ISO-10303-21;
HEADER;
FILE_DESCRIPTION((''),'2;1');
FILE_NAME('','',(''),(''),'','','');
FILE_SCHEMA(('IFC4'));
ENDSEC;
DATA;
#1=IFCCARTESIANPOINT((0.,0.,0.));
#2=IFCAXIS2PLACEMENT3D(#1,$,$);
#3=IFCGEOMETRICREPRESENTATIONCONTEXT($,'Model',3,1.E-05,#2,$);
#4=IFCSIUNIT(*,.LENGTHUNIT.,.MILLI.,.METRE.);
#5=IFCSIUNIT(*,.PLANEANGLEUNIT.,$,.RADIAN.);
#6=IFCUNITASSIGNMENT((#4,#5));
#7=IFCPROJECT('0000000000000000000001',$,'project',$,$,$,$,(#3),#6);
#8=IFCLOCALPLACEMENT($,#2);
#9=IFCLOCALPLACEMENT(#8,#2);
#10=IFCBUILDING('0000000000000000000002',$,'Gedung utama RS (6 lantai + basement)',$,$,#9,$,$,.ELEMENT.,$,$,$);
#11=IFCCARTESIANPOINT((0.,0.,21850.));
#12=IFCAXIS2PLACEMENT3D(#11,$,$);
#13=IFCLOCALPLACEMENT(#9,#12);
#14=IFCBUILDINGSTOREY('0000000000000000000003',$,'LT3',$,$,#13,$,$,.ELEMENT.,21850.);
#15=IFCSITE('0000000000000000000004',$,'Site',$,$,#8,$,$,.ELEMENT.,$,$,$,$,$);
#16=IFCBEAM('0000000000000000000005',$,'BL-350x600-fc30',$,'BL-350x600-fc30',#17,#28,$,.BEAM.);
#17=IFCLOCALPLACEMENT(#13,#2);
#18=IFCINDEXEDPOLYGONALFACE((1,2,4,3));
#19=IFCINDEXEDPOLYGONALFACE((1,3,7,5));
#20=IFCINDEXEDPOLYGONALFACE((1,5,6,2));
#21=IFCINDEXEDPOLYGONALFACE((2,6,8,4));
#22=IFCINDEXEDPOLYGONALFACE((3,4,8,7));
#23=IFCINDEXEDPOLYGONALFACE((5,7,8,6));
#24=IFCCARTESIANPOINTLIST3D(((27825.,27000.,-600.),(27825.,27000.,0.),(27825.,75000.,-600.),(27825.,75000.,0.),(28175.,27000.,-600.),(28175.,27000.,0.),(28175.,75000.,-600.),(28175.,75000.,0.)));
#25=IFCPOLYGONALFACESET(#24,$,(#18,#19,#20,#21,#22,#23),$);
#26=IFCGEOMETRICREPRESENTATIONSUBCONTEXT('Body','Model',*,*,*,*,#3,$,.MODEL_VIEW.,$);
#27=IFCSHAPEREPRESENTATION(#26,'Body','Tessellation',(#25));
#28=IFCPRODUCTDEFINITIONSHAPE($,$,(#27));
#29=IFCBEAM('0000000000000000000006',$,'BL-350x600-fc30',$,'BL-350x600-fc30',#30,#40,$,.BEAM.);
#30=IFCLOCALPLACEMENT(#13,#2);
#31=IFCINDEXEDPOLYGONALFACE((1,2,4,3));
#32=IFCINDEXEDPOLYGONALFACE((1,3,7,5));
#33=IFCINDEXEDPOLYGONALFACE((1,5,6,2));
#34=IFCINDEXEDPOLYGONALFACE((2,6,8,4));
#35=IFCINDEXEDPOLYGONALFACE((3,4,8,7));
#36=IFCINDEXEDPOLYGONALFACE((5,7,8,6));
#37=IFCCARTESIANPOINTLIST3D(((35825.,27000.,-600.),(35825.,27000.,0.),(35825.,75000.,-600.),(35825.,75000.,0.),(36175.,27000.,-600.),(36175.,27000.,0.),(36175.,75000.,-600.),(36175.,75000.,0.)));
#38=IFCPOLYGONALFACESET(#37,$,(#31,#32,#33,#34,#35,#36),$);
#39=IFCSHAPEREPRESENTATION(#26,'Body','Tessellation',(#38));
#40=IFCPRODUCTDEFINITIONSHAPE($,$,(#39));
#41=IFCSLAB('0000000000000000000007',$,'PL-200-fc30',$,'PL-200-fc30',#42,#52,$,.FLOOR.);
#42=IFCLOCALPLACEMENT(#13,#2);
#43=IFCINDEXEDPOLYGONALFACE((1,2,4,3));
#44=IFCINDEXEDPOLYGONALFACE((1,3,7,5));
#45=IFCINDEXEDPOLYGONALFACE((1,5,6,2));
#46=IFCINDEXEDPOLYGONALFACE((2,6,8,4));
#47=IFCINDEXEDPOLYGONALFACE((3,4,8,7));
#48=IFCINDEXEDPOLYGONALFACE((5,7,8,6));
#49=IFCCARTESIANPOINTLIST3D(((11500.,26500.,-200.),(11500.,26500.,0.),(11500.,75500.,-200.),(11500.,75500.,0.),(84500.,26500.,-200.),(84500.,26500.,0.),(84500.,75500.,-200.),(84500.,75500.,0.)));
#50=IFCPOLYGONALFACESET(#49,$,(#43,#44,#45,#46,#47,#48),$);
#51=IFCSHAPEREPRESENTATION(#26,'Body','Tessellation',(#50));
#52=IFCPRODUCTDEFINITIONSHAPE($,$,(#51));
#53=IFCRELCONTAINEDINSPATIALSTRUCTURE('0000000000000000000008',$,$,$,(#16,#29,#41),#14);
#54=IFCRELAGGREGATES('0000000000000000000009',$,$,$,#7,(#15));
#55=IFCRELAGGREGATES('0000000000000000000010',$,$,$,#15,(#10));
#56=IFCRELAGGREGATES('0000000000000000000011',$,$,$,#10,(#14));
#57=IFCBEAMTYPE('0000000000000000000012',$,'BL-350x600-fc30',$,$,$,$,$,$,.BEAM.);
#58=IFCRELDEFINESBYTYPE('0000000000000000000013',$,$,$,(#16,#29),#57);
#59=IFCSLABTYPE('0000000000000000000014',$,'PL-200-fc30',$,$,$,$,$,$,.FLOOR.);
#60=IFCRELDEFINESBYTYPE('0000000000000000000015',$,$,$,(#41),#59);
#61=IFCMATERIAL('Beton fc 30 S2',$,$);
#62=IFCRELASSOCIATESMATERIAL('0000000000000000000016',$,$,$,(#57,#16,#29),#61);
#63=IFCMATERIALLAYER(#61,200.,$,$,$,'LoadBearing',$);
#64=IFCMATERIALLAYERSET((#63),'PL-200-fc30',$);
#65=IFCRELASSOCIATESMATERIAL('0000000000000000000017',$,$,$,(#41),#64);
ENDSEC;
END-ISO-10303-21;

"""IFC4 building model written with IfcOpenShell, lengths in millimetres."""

from ifc_helpers import new_model, si_unit, frame, origin, origin_2d, place, context, subcontext, project, spatial, polyline, rectangle, outline, extrude, material, layer, layer_set, layer_usage, material_profile, profile_set, profile_usage, type_object, element, save


model = new_model("IFC4")

# Units and contexts
model_context = context("Model", 3, precision=1e-05, world=origin())
body_context = subcontext(model_context, "Body", "Model", "MODEL_VIEW")
ifc_project = project(units=[si_unit("LENGTHUNIT", "METRE", prefix="MILLI"), si_unit("PLANEANGLEUNIT", "RADIAN")], contexts=[model_context])

# Site, building, storey
site_placement = place(None, origin())
site = spatial("IfcSite", under=ifc_project, at=site_placement, Name="Site", CompositionType="ELEMENT")
building_placement = place(site_placement, origin())
building = spatial("IfcBuilding", under=site, at=building_placement, Name="Gedung utama RS (6 lantai + basement)", CompositionType="ELEMENT")
storey_placement = place(building_placement, frame((0.0, 0.0, 21850.0)))
storey = spatial("IfcBuildingStorey", under=building, at=storey_placement, Name="LT3", CompositionType="ELEMENT", Elevation=21850.0)

# Beams
ifc_material = material(Name="Beton fc 30 S2")
ifc_material_profile_1 = material_profile(ifc_material, rectangle(XDim=350.0, YDim=600.0, at=origin_2d()), Name="BL-350x600-fc30")
ifc_profile_set_1 = profile_set([ifc_material_profile_1], Name="BL-350x600-fc30")
ifc_profile_usage_1 = profile_usage(ifc_profile_set_1, cardinal=8)
beam_type = type_object("IfcBeamType", Name="BL-350x600-fc30", PredefinedType="BEAM", material=ifc_profile_set_1)
for number, where, name in (
    (1, (28000.0, 27000.0, -300.0), "BL-350x600-fc30"),
    (2, (36000.0, 27000.0, -300.0), "BL-350x600-fc30"),
):
    element("IfcBeam", number, at=place(storey_placement, frame(where)), inside=storey, type_object=beam_type, material=ifc_profile_usage_1, Name=name, ObjectType="BL-350x600-fc30", PredefinedType="BEAM", context=body_context, shape_type="SweptSolid", body=[
        extrude(rectangle(XDim=350.0, YDim=600.0, at=origin_2d()), frame((0.0, 0.0, 0.0), z_axis=(0.0, 1.0, 0.0), x_axis=(-1.0, 0.0, 0.0)), (0.0, 0.0, 1.0), 48000.0),
    ])

# Slab
ifc_layer = layer(ifc_material, 200.0, Category="LoadBearing")
ifc_layer_set = layer_set([ifc_layer], Name="PL-200-fc30")
ifc_layer_usage = layer_usage(ifc_layer_set, "AXIS3", "NEGATIVE", 0.0)
slab_type = type_object("IfcSlabType", Name="PL-200-fc30", PredefinedType="FLOOR")
slab_placement = place(storey_placement, origin())
element("IfcSlab", 3, at=slab_placement, inside=storey, type_object=slab_type, material=ifc_layer_usage, Name="PL-200-fc30", ObjectType="PL-200-fc30", PredefinedType="FLOOR", context=body_context, shape_type="SweptSolid", body=[
    extrude(outline(polyline([(11500.0, 26500.0), (84500.0, 26500.0), (84500.0, 75500.0), (11500.0, 75500.0), (11500.0, 26500.0)])), frame((0.0, 0.0, -200.0)), (0.0, 0.0, 1.0), 200.0),
])

save(model, "model.ifc")
